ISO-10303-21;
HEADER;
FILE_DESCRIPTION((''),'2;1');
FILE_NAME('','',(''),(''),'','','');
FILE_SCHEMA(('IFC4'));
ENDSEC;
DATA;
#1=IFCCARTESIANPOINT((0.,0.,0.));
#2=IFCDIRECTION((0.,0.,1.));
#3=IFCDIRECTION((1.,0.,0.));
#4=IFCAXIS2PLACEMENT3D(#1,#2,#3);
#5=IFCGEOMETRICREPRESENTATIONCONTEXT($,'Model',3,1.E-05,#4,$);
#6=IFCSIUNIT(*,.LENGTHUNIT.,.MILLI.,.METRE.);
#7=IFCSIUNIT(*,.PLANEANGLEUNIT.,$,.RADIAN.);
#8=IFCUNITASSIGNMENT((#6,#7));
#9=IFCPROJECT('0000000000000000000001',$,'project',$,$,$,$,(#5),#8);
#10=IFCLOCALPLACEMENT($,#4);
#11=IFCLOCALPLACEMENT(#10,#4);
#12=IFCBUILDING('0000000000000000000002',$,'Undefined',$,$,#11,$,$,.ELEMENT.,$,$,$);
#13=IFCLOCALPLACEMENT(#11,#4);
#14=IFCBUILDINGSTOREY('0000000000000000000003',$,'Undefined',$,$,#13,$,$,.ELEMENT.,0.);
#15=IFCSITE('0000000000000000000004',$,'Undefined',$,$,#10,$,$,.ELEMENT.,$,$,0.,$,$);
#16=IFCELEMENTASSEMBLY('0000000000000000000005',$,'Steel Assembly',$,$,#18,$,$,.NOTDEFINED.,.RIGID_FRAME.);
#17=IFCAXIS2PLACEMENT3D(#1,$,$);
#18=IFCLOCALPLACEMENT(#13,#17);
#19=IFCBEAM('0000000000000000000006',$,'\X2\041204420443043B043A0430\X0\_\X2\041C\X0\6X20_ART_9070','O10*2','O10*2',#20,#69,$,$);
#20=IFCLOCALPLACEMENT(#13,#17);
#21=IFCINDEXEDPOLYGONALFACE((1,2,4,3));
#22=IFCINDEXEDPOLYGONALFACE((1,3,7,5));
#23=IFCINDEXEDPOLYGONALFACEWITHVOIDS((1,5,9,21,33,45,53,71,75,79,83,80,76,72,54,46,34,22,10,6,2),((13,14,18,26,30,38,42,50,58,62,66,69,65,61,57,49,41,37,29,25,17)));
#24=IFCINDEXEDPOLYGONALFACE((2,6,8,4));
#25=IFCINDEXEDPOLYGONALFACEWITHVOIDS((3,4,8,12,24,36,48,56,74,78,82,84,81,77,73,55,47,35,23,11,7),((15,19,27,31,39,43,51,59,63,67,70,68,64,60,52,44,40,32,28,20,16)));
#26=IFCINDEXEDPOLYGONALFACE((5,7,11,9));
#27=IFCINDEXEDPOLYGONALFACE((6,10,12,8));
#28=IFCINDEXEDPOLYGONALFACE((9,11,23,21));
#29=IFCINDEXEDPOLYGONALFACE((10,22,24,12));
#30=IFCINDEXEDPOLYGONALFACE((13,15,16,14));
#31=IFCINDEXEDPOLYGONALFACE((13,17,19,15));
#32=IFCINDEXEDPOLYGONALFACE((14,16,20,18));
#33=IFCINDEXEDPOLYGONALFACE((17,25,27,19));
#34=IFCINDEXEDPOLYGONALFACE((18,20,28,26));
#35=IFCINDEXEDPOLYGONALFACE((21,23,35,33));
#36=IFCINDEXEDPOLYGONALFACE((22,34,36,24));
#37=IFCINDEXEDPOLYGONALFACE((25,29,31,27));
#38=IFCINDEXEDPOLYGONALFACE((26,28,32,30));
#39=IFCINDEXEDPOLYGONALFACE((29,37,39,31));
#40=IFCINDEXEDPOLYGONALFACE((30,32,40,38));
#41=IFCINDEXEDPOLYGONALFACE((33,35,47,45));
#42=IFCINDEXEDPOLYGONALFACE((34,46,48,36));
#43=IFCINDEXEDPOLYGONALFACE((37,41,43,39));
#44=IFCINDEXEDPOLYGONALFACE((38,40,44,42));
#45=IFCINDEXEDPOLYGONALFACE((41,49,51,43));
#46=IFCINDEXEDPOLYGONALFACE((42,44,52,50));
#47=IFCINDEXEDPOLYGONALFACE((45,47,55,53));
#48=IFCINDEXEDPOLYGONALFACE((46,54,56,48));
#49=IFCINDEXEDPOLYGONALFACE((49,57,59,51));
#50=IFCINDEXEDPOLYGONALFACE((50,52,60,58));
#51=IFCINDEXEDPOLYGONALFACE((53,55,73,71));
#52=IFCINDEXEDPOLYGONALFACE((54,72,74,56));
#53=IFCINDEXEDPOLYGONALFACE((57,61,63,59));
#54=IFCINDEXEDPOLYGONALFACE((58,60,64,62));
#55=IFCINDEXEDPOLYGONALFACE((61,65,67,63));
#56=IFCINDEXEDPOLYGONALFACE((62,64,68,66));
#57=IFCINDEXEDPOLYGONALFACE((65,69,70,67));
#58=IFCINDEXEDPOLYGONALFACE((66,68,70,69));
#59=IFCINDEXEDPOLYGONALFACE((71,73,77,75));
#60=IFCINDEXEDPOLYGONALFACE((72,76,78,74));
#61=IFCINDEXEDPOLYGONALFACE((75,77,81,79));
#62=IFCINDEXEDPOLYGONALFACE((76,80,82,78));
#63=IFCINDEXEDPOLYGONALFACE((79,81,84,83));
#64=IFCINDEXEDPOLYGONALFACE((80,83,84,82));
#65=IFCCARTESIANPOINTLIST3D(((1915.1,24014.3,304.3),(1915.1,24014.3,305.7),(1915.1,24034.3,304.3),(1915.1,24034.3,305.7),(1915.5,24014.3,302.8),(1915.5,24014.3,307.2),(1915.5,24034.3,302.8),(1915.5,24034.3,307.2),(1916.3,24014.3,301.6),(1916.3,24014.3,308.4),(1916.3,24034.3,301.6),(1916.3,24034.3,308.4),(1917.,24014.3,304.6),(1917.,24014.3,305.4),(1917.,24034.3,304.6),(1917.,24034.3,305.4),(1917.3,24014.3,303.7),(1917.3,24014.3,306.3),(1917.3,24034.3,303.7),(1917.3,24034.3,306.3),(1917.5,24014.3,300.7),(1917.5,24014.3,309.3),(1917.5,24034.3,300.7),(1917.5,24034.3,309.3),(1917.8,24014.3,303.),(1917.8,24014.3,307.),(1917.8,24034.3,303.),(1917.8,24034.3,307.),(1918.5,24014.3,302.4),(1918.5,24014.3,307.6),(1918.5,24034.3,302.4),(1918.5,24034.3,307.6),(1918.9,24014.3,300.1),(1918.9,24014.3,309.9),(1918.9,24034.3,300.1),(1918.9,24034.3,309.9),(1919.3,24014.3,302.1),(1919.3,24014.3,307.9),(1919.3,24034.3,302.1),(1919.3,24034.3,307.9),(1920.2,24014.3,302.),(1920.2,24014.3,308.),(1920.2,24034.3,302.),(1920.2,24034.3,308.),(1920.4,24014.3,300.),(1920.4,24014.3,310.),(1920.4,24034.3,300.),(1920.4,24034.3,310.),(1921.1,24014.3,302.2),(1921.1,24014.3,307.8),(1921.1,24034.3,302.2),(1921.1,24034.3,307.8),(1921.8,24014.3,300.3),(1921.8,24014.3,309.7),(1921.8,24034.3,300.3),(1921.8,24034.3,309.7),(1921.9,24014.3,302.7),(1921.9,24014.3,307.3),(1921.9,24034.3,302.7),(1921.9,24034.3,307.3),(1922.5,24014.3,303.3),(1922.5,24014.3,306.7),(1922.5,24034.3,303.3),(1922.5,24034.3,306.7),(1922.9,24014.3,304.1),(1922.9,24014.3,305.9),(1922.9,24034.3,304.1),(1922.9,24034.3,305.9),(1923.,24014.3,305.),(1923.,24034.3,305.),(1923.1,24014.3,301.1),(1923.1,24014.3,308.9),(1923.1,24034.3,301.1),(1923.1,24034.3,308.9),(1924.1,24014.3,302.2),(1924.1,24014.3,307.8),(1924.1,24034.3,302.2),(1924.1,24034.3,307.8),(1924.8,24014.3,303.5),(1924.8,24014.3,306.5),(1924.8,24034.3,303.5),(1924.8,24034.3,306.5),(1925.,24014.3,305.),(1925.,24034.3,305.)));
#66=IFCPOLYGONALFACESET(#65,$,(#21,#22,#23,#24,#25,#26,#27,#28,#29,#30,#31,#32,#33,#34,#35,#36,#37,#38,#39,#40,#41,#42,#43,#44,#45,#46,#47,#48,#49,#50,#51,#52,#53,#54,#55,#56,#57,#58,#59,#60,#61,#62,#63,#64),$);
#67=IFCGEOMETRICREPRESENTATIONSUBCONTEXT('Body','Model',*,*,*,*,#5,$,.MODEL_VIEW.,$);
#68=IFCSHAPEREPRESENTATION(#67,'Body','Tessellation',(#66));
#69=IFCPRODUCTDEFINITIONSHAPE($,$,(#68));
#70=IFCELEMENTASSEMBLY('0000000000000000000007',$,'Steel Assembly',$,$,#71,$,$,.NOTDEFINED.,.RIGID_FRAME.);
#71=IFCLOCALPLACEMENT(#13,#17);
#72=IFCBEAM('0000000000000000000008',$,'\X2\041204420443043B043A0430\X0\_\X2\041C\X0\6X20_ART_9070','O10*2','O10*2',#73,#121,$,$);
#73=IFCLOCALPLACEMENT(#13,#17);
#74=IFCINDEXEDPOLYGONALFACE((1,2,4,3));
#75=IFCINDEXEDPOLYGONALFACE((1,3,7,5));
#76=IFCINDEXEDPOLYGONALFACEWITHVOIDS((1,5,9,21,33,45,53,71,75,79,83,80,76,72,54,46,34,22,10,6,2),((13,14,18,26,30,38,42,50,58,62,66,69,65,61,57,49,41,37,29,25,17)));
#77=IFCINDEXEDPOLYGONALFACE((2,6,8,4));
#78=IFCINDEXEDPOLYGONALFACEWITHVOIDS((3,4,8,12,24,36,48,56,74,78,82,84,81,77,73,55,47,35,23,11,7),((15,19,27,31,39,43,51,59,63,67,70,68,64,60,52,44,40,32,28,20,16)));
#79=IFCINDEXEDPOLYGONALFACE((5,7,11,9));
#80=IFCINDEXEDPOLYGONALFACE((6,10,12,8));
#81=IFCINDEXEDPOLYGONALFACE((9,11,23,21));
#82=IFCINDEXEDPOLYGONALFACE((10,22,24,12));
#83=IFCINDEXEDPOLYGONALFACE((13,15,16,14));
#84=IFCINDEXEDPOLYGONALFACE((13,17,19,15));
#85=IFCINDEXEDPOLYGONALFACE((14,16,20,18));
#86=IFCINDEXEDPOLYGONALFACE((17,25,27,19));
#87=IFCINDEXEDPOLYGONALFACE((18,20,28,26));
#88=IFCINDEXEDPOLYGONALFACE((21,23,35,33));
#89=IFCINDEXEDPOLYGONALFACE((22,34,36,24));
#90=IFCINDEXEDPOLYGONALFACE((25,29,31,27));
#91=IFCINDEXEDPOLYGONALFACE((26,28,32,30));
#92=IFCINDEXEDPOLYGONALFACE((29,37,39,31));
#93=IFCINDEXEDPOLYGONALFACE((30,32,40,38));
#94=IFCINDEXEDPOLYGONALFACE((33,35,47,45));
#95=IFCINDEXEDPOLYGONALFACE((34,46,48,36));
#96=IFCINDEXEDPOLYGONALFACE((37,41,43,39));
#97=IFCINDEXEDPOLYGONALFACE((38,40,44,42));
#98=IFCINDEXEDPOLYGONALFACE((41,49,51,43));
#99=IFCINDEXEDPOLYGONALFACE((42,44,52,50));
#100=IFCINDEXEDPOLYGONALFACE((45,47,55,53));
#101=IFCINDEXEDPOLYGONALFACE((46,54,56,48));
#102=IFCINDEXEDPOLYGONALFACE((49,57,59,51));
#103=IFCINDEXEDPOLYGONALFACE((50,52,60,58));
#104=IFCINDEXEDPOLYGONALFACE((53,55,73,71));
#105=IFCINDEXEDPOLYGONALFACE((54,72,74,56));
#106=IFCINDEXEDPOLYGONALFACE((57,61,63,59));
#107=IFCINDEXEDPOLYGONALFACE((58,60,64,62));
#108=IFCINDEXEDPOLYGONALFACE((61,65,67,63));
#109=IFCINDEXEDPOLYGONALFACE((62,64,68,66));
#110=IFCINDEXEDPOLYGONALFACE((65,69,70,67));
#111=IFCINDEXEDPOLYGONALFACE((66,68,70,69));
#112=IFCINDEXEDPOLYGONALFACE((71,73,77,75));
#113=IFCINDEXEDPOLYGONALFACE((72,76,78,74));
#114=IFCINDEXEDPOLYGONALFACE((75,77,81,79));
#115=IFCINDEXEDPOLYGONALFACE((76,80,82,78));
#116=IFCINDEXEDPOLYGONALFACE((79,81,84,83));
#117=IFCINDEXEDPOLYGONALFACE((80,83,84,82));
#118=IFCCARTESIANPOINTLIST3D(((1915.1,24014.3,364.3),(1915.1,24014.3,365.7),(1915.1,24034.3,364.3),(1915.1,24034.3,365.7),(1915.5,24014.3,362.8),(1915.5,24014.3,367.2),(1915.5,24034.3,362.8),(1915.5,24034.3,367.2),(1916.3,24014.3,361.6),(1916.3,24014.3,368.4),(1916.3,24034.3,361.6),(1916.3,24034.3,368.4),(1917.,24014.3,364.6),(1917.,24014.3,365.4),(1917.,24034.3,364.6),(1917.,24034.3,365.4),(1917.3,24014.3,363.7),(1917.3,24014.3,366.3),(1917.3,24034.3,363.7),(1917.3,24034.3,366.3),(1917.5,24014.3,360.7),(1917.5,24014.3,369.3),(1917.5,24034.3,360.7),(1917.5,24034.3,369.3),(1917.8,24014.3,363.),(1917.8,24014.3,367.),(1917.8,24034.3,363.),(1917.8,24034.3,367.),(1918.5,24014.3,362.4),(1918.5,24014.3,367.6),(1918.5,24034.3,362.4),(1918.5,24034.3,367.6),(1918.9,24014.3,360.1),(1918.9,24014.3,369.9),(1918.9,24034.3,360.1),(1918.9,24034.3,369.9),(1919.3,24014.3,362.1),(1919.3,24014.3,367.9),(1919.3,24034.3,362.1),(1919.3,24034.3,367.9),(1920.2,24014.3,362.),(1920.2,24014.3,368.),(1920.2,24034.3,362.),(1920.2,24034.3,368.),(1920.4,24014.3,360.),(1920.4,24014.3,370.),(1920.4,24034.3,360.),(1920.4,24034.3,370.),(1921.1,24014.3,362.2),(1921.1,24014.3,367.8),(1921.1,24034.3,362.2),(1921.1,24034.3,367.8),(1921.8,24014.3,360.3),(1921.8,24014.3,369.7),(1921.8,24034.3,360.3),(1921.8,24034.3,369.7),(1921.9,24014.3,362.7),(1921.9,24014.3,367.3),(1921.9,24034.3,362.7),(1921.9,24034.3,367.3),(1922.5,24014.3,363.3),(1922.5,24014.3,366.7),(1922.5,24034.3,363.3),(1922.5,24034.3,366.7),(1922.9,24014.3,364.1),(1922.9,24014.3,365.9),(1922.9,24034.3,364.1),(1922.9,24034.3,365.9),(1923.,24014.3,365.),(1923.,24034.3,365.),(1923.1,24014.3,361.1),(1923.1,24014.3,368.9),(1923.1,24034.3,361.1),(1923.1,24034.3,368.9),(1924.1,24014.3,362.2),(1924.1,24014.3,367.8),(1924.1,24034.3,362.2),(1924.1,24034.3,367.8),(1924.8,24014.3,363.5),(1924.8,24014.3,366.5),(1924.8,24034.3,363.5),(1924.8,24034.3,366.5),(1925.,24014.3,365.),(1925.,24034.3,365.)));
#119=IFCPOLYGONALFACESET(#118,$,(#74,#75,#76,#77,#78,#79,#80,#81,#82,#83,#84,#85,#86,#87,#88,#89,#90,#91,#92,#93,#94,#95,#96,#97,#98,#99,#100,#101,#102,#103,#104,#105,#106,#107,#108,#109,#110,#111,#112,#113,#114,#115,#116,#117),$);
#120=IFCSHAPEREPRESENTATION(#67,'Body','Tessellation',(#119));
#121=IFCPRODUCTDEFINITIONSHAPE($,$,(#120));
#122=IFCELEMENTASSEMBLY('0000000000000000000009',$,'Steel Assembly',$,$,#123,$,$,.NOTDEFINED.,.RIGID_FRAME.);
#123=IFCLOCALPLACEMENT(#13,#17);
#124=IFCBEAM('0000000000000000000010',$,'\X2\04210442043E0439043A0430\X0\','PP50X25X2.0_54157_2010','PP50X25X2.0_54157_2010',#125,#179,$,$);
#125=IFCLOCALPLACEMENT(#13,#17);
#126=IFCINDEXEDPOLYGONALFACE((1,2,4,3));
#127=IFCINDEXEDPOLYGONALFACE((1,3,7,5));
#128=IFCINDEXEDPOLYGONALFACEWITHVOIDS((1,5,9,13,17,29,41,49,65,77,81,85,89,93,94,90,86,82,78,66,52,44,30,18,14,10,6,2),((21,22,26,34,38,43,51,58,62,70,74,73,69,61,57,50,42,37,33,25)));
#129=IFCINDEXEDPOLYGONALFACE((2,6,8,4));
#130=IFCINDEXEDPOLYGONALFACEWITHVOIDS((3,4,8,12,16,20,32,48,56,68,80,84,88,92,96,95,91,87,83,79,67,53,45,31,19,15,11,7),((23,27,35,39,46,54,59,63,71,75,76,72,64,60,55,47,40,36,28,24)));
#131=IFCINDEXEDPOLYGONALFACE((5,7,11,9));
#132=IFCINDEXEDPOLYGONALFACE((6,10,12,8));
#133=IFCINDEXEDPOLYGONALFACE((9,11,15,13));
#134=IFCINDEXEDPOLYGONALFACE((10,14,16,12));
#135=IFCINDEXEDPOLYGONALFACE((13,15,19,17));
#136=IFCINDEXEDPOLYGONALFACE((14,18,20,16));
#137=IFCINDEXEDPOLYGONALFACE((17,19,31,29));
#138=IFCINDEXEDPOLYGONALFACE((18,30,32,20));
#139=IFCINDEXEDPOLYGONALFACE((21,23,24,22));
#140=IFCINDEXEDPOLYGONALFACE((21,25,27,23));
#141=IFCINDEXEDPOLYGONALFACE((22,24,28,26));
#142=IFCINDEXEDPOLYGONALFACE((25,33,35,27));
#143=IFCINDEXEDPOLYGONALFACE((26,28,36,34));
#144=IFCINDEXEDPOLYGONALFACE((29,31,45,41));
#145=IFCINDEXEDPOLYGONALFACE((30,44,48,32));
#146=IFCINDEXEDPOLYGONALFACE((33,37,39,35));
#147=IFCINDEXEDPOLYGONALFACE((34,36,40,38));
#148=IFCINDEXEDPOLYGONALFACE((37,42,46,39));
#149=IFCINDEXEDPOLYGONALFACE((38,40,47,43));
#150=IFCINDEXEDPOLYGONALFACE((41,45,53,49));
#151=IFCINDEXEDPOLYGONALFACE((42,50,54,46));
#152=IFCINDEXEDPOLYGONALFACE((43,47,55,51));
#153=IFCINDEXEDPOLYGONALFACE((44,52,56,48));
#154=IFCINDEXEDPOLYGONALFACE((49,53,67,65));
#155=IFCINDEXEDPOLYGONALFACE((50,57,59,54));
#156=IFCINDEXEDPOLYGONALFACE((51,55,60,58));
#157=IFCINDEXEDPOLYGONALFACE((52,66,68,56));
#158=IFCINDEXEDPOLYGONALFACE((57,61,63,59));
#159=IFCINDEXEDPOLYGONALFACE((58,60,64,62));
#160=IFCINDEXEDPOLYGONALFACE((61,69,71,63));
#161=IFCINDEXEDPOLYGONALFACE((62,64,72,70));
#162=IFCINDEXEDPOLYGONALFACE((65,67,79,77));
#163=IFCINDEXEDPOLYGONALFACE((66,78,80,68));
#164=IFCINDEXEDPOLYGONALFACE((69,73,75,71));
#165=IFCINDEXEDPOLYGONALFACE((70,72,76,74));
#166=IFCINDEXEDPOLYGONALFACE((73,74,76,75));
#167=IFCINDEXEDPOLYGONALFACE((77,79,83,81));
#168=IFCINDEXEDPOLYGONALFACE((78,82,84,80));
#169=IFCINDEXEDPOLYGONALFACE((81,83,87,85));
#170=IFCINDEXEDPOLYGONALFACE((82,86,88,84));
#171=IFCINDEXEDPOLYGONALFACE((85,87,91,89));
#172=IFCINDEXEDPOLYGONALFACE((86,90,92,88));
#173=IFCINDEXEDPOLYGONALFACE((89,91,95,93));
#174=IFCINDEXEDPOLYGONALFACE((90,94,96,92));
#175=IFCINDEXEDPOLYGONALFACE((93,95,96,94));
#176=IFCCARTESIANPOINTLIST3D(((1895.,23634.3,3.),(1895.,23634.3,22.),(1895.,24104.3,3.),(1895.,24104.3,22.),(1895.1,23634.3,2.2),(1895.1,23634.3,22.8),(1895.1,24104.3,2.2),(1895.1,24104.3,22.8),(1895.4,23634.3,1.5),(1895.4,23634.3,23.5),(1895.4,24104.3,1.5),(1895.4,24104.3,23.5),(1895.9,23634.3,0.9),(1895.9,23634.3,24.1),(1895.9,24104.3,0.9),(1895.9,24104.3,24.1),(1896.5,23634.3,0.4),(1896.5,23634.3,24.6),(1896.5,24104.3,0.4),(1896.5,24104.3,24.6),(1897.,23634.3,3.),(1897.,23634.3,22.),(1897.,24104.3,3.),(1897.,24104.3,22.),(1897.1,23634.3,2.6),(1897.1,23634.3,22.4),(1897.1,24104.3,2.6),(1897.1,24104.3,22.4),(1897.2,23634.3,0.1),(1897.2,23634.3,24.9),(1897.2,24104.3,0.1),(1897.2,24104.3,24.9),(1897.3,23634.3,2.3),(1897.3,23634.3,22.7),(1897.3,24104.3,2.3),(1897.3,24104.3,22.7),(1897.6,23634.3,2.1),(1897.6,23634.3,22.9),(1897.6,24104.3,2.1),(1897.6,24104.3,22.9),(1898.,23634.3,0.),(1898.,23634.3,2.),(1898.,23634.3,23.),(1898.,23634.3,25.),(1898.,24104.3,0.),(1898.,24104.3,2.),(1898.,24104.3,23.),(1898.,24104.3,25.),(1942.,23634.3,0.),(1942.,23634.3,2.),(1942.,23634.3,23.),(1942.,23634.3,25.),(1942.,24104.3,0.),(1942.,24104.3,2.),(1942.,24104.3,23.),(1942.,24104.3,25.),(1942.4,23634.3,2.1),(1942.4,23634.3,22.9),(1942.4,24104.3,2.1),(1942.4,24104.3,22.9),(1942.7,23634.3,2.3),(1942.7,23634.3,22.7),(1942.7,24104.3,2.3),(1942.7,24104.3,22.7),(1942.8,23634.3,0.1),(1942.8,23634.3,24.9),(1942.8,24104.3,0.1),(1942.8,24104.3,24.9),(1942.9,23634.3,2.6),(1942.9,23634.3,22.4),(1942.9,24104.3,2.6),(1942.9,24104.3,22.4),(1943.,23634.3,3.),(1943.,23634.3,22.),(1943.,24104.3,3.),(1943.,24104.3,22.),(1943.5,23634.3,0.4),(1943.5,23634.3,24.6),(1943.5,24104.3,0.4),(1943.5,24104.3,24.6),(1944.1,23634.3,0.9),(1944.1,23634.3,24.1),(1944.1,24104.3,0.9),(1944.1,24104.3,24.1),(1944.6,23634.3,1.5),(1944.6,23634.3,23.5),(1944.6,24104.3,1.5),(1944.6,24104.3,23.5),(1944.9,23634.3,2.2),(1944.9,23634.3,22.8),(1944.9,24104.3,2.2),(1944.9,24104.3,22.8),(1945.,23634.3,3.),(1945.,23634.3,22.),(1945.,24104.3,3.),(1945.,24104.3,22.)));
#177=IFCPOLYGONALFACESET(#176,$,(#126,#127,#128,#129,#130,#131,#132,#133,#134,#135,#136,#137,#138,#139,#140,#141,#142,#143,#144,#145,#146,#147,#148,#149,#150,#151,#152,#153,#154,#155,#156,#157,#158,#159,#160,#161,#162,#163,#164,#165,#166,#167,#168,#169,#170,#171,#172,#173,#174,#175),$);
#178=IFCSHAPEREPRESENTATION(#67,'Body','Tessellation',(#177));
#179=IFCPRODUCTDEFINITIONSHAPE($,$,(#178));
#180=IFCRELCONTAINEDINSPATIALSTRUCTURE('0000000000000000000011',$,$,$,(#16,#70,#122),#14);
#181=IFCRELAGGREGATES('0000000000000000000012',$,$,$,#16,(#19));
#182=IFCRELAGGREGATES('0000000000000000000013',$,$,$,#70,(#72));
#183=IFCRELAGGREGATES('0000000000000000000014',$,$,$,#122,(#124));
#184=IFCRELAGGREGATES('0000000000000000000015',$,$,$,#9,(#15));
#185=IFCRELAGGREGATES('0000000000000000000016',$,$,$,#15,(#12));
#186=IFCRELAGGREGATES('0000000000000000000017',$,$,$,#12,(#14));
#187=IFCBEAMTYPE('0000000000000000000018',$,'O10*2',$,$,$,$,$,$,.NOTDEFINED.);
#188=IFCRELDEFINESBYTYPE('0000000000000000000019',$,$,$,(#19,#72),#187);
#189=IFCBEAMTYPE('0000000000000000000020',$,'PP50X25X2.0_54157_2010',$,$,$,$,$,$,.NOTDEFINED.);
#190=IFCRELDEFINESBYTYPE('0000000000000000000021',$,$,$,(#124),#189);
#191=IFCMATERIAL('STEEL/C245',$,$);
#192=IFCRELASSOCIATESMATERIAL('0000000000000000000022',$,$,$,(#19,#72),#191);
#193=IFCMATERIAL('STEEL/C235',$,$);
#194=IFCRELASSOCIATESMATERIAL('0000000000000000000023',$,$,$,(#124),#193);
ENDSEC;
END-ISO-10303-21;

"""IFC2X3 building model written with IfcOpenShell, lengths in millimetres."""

from ifc_helpers import new_model, si_unit, frame, origin_with_axes, origin_2d_with_axis, place, context, subcontext, project, spatial, hollow_rectangle, hollow_circle, extrude, material, type_object, element, aggregate, save


model = new_model("IFC2X3")

# Units and contexts
model_context = context("Model", 3, precision=1e-05, world=origin_with_axes())
body_context = subcontext(model_context, "Body", "Model", "MODEL_VIEW")
ifc_project = project(units=[si_unit("LENGTHUNIT", "METRE", prefix="MILLI"), si_unit("PLANEANGLEUNIT", "RADIAN")], contexts=[model_context])

# Site, building, storey
site_placement = place(None, origin_with_axes())
site = spatial("IfcSite", under=ifc_project, at=site_placement, Name="Undefined", CompositionType="ELEMENT", RefElevation=0.0)
building_placement = place(site_placement, origin_with_axes())
building = spatial("IfcBuilding", under=site, at=building_placement, Name="Undefined", CompositionType="ELEMENT")
storey_placement = place(building_placement, origin_with_axes())
storey = spatial("IfcBuildingStorey", under=building, at=storey_placement, Name="Undefined", CompositionType="ELEMENT", Elevation=0.0)

# Element assemblies, beams
ifc_material_1 = material(Name="STEEL/C235")
ifc_material_2 = material(Name="STEEL/C245")
beam_type_1 = type_object("IfcBeamType", Name="O10*2", PredefinedType="NOTDEFINED")
assembly_1_placement = place(storey_placement, origin_with_axes())
assembly_1 = element("IfcElementAssembly", 1, at=assembly_1_placement, inside=storey, Name="Steel Assembly", AssemblyPlace="NOTDEFINED", PredefinedType="RIGID_FRAME")
beam_1_placement = place(assembly_1_placement, frame((1920.0, 24014.3, 305.0), z_axis=(0.0, 0.0, 1.0), x_axis=(0.0, 1.0, 0.0)))
beam_1 = element("IfcBeam", 2, at=beam_1_placement, type_object=beam_type_1, material=ifc_material_2, Name="Втулка_М6X20_ART_9070", Description="O10*2", ObjectType="O10*2", context=body_context, shape_type="SweptSolid", body=[
    extrude(hollow_circle(Radius=5.0, WallThickness=2.0, at=origin_2d_with_axis()), frame((20.0, 0.0, 0.0), z_axis=(-1.0, 0.0, 0.0), x_axis=(0.0, -1.0, 0.0)), (0.0, 0.0, 1.0), 20.0),
])
aggregate(assembly_1, [beam_1])
assembly_2_placement = place(storey_placement, origin_with_axes())
assembly_2 = element("IfcElementAssembly", 3, at=assembly_2_placement, inside=storey, Name="Steel Assembly", AssemblyPlace="NOTDEFINED", PredefinedType="RIGID_FRAME")
beam_2_placement = place(assembly_2_placement, frame((1920.0, 24014.3, 365.0), z_axis=(0.0, 0.0, 1.0), x_axis=(0.0, 1.0, 0.0)))
beam_2 = element("IfcBeam", 4, at=beam_2_placement, type_object=beam_type_1, material=ifc_material_2, Name="Втулка_М6X20_ART_9070", Description="O10*2", ObjectType="O10*2", context=body_context, shape_type="SweptSolid", body=[
    extrude(hollow_circle(Radius=5.0, WallThickness=2.0, at=origin_2d_with_axis()), frame((20.0, 0.0, 0.0), z_axis=(-1.0, 0.0, 0.0), x_axis=(0.0, -1.0, 0.0)), (0.0, 0.0, 1.0), 20.0),
])
aggregate(assembly_2, [beam_2])
assembly_3_placement = place(storey_placement, origin_with_axes())
assembly_3 = element("IfcElementAssembly", 5, at=assembly_3_placement, inside=storey, Name="Steel Assembly", AssemblyPlace="NOTDEFINED", PredefinedType="RIGID_FRAME")
beam_type_2 = type_object("IfcBeamType", Name="PP50X25X2.0_54157_2010", PredefinedType="NOTDEFINED")
beam_3_placement = place(assembly_3_placement, frame((1920.0, 24104.3, 12.5), z_axis=(-1.0, 0.0, 0.0), x_axis=(0.0, -1.0, 0.0)))
beam_3 = element("IfcBeam", 6, at=beam_3_placement, type_object=beam_type_2, material=ifc_material_1, Name="Стойка", Description="PP50X25X2.0_54157_2010", ObjectType="PP50X25X2.0_54157_2010", context=body_context, shape_type="SweptSolid", body=[
    extrude(hollow_rectangle(XDim=25.0, YDim=50.0, WallThickness=2.0, InnerFilletRadius=1.0, OuterFilletRadius=3.0, at=origin_2d_with_axis()), frame((470.0, 0.0, 0.0), z_axis=(-1.0, 0.0, 0.0), x_axis=(0.0, -1.0, 0.0)), (0.0, 0.0, 1.0), 470.0),
])

aggregate(assembly_3, [beam_3])

save(model, "model.ifc")
